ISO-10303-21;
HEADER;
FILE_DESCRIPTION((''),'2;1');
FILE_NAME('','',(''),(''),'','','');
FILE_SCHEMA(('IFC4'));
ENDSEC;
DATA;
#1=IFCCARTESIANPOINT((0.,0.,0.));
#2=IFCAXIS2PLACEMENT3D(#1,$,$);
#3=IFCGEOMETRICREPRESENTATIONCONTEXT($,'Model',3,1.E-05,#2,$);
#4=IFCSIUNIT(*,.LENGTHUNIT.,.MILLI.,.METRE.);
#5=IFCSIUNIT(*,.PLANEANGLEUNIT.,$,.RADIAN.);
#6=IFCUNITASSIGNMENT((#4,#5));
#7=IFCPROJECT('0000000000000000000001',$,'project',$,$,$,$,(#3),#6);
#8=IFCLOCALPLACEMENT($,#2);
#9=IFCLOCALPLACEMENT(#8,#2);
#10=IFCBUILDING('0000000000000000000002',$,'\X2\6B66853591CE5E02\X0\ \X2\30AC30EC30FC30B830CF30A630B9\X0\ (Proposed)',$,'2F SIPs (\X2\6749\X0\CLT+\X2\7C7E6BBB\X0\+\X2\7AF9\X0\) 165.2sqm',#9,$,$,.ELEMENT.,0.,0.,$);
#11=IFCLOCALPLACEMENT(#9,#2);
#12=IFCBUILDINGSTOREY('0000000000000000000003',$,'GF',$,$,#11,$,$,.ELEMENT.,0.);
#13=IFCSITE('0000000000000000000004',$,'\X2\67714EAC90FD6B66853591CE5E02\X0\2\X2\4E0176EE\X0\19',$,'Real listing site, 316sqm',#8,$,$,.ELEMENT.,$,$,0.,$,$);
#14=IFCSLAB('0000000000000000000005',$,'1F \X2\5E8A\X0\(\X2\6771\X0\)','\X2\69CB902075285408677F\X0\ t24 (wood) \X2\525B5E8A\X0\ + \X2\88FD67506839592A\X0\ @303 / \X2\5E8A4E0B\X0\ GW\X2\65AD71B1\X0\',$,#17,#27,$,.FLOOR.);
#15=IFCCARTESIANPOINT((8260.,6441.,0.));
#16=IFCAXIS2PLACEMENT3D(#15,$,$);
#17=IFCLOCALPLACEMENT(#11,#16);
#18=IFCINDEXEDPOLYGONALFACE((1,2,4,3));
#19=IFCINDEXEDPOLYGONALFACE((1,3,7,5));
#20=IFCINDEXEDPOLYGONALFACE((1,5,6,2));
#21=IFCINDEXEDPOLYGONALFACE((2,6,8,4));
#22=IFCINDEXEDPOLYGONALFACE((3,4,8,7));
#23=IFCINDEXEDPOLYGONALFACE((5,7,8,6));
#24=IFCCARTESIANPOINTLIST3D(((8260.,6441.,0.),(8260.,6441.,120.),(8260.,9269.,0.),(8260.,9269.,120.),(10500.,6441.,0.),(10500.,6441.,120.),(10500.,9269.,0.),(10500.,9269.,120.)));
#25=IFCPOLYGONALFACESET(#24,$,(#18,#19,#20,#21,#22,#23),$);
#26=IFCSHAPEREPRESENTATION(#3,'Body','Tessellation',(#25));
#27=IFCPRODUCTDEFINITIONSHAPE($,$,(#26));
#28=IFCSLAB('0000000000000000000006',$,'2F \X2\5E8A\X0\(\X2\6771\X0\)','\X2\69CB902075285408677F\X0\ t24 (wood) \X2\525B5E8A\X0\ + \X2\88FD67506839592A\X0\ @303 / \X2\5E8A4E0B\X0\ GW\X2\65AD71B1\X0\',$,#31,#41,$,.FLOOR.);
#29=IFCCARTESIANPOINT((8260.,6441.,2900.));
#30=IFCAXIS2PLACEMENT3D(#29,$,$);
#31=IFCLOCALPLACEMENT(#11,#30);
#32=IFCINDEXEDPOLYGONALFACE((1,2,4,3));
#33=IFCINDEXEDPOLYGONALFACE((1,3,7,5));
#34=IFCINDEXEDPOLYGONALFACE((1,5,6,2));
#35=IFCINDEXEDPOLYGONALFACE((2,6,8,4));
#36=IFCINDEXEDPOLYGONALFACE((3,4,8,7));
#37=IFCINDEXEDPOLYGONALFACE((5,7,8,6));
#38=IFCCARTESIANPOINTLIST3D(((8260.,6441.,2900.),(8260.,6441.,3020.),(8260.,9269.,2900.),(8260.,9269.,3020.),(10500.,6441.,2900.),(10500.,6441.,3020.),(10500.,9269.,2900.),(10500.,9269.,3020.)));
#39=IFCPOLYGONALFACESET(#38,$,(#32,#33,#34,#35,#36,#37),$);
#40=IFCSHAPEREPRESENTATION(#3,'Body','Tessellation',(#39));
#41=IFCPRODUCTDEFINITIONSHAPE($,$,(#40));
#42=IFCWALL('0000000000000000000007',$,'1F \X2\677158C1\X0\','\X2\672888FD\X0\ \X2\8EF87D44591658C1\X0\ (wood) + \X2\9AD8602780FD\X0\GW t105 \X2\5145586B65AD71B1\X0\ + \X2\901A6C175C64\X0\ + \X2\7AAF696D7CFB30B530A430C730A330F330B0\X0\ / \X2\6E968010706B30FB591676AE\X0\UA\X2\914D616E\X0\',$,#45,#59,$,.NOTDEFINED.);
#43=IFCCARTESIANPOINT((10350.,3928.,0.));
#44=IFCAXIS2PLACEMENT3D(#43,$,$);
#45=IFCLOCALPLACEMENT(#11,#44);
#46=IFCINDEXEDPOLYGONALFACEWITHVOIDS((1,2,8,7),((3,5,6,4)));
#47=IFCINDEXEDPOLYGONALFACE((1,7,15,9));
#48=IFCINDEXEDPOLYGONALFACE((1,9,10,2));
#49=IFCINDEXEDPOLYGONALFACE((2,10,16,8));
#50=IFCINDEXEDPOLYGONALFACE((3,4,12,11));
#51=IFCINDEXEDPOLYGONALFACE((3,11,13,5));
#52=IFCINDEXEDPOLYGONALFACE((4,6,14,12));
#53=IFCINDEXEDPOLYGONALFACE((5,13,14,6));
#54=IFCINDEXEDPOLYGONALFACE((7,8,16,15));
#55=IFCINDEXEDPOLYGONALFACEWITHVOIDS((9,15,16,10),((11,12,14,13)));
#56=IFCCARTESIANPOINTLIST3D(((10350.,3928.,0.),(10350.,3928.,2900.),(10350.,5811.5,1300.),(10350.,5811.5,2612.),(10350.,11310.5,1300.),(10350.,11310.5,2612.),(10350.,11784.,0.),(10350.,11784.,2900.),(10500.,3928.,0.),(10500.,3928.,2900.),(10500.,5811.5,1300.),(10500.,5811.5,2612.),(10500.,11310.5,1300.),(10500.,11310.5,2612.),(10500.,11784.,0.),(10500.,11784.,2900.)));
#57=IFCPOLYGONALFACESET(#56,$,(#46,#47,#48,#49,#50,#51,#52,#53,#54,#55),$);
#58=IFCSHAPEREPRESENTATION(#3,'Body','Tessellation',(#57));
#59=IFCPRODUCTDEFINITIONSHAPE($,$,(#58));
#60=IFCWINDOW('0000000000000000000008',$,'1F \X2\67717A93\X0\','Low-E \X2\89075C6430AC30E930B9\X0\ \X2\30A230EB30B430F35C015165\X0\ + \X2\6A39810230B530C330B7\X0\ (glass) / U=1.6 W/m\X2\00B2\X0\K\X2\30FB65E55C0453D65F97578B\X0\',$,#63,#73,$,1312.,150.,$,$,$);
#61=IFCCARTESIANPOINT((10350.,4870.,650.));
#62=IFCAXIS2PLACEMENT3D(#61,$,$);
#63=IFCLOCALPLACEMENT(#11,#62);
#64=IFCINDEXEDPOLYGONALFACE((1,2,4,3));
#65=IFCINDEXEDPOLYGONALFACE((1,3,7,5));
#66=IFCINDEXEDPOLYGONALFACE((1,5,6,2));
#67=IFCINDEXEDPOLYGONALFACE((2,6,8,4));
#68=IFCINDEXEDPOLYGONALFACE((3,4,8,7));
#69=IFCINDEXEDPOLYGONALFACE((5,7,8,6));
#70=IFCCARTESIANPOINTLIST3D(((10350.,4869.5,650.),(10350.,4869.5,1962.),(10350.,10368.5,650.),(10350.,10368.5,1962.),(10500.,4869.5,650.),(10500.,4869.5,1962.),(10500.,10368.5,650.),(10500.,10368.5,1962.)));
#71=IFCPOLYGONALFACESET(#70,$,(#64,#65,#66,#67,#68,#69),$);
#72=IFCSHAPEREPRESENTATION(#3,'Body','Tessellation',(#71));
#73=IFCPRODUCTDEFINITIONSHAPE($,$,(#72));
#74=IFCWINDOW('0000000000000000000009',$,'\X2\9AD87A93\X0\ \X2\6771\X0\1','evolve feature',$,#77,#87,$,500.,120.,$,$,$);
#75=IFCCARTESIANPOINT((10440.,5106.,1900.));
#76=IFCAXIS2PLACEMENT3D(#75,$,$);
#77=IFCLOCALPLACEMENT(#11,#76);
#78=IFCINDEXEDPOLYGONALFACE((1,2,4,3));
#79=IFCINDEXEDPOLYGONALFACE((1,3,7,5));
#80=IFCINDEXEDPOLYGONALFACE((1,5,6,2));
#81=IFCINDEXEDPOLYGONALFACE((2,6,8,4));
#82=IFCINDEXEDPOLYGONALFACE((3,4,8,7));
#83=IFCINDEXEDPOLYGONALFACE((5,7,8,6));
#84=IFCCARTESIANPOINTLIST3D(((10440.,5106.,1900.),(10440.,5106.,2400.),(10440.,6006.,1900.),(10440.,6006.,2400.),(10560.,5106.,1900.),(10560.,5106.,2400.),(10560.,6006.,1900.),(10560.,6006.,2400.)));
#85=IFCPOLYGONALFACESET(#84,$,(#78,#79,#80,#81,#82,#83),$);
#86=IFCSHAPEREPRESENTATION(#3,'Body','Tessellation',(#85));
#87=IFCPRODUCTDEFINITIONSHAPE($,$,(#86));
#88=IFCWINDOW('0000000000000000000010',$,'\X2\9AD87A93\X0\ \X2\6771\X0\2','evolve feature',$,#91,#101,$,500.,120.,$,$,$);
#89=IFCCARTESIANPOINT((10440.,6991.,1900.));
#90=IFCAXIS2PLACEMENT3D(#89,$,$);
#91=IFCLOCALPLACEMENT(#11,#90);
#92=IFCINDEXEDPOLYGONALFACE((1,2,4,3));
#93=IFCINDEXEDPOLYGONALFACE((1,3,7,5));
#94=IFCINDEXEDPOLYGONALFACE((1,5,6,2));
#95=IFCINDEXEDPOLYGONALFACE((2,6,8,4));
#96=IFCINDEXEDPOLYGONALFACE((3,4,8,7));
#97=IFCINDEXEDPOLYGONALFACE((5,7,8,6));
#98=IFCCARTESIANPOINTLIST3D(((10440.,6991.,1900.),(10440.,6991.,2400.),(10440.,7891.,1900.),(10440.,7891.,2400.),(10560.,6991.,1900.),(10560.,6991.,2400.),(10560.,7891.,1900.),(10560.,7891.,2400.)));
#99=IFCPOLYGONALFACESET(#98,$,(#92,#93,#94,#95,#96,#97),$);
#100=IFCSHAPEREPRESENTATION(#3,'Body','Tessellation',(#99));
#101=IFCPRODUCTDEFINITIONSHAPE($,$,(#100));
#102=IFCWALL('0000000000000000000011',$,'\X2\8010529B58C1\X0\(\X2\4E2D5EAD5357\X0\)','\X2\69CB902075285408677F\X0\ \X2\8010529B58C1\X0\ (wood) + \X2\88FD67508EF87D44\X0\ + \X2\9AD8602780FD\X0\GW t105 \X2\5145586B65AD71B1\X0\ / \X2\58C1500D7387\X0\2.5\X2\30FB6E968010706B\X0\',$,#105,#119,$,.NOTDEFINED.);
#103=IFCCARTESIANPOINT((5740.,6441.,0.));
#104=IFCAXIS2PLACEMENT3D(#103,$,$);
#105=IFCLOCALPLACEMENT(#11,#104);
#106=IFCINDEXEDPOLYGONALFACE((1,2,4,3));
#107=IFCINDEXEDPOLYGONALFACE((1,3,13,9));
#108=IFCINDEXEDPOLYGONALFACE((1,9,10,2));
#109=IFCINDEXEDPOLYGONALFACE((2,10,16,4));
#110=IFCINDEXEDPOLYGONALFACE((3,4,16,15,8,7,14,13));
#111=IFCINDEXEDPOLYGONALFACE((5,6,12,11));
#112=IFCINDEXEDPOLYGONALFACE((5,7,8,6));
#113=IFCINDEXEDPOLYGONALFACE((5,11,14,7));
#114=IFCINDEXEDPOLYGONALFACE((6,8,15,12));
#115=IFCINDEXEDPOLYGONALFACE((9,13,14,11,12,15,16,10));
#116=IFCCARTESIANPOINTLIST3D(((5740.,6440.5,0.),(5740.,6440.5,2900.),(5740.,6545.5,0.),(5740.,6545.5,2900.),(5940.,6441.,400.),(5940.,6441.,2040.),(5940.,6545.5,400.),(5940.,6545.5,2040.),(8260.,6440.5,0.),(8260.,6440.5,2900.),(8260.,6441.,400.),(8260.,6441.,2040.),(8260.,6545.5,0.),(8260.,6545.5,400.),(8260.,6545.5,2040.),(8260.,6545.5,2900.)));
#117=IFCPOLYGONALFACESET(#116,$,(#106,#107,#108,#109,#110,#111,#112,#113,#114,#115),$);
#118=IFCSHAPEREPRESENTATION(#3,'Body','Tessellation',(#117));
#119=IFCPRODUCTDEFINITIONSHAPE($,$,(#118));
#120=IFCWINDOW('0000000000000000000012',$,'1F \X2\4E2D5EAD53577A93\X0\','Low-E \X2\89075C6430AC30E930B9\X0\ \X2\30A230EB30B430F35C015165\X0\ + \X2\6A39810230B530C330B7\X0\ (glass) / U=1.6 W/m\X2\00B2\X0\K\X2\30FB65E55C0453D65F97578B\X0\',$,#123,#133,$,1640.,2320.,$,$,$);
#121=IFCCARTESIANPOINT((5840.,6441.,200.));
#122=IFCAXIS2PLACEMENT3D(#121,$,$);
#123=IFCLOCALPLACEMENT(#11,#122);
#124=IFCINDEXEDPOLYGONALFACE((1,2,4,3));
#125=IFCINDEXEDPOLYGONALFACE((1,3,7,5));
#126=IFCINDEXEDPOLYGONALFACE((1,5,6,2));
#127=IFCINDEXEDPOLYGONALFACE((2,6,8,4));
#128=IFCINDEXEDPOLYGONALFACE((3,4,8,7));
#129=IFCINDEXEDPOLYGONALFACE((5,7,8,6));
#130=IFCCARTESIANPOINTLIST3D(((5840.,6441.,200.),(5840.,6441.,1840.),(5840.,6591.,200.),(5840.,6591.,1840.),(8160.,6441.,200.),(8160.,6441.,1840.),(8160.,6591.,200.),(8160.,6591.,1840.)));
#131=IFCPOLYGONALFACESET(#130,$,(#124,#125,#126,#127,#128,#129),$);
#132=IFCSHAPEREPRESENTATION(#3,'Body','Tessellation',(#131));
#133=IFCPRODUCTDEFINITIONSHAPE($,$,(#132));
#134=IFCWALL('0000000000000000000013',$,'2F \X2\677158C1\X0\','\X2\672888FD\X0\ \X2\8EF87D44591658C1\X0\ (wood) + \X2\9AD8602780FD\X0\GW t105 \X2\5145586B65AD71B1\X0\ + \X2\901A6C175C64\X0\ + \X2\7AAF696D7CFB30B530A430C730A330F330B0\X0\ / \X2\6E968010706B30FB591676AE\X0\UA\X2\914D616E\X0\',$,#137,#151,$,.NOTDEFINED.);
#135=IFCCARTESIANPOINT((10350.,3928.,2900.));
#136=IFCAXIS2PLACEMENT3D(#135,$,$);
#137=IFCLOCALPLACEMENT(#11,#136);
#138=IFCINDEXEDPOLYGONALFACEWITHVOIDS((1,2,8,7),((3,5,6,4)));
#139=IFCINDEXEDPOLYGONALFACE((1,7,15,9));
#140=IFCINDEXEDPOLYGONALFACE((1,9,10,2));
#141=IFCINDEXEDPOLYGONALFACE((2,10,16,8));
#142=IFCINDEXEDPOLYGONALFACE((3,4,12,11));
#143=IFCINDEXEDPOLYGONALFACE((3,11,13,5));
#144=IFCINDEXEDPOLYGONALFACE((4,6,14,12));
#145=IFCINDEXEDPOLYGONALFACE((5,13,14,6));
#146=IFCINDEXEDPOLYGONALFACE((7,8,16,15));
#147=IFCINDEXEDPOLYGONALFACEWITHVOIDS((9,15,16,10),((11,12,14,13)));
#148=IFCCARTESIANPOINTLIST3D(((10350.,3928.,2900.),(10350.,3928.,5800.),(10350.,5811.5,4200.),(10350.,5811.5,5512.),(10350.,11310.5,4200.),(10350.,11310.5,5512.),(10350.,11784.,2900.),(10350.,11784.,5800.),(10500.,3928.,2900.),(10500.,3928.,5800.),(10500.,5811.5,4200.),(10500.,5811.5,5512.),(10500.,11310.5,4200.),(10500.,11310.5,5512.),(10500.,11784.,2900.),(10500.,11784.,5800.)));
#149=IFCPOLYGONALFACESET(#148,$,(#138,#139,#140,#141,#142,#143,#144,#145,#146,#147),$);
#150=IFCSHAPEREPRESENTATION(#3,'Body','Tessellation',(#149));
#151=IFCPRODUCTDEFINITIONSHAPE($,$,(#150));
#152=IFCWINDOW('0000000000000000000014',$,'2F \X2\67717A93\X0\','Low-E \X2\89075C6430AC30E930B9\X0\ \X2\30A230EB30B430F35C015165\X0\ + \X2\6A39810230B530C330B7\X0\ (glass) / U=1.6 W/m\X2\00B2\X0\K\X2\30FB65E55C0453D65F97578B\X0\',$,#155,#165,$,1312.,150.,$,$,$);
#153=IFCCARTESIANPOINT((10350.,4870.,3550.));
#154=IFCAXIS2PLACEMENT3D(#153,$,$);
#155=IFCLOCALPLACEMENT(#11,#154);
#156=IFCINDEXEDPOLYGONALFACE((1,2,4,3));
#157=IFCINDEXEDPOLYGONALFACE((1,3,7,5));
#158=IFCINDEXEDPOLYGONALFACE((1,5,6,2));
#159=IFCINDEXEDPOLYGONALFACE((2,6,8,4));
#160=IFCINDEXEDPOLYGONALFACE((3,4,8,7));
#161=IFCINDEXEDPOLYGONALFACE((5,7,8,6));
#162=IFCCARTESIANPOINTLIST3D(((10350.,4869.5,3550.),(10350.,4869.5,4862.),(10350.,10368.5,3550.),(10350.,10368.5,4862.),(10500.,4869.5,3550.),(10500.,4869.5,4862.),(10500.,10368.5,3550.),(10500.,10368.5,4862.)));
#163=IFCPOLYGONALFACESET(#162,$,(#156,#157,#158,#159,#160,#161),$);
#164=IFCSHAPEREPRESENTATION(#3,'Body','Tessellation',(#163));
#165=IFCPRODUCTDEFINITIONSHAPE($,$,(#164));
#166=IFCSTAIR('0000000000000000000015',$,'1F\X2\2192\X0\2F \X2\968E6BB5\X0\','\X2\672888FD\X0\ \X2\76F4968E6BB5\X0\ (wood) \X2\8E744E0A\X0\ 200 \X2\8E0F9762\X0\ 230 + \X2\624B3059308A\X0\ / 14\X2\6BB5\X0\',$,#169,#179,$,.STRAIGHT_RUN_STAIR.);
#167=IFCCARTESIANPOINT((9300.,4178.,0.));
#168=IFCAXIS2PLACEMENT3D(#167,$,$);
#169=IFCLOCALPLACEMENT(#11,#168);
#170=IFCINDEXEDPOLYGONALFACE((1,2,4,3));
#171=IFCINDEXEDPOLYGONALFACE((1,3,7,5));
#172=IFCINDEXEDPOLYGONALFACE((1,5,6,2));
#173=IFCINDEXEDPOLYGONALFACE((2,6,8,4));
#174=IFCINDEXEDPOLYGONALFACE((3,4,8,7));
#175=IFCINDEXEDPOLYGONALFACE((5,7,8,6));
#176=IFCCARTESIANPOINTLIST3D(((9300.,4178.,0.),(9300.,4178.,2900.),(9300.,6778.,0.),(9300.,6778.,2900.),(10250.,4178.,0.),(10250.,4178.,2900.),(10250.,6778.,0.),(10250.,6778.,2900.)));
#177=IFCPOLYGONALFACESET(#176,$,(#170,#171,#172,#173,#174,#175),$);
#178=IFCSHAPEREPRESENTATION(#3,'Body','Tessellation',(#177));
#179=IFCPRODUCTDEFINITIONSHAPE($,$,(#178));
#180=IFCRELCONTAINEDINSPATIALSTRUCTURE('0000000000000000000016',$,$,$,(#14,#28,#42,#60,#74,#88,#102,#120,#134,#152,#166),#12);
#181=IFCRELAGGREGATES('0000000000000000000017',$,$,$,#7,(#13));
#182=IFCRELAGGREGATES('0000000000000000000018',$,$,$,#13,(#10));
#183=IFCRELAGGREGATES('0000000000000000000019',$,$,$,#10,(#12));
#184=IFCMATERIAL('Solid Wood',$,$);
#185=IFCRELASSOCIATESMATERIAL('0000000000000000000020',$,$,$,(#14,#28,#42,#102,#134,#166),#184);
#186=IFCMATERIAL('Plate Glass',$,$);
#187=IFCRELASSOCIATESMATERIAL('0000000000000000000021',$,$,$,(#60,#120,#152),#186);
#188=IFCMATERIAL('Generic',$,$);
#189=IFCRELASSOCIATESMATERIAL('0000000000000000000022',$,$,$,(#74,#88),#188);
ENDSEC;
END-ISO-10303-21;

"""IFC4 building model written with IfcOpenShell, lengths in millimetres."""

from ifc_helpers import new_model, si_unit, frame, frame_2d, origin, place, context, project, spatial, rectangle, extrude, material, element, fill, save


model = new_model("IFC4")

# Units and contexts
model_context = context("Model", 3, precision=1e-05, world=origin())
ifc_project = project(units=[si_unit("LENGTHUNIT", "METRE", prefix="MILLI"), si_unit("PLANEANGLEUNIT", "RADIAN")], contexts=[model_context])

# Site, building, storey
site_placement = place(None, origin())
site = spatial("IfcSite", under=ifc_project, at=site_placement, Name="東京都武蔵野市2丁目19", ObjectType="Real listing site, 316sqm", CompositionType="ELEMENT", RefElevation=0.0)
building_placement = place(site_placement, origin())
building = spatial("IfcBuilding", under=site, at=building_placement, Name="武蔵野市 ガレージハウス (Proposed)", ObjectType="2F SIPs (杉CLT+籾殻+竹) 165.2sqm", CompositionType="ELEMENT", ElevationOfRefHeight=0.0, ElevationOfTerrain=0.0)
storey_placement = place(building_placement, origin())
storey = spatial("IfcBuildingStorey", under=building, at=storey_placement, Name="GF", CompositionType="ELEMENT", Elevation=0.0)

# Slabs
ifc_material_1 = material(Name="Solid Wood")
slab_1_placement = place(storey_placement, frame((8260.0, 6441.0, 0.0)))
element("IfcSlab", 1, at=slab_1_placement, inside=storey, material=ifc_material_1, Name="1F 床(東)", Description="構造用合板 t24 (wood) 剛床 + 製材根太 @303 / 床下 GW断熱", PredefinedType="FLOOR", context=model_context, shape_type="SweptSolid", body=[
    extrude(rectangle(XDim=2240.0, YDim=2828.0, at=frame_2d((1120.0, 1414.0))), frame((8260.0, 6441.0, 0.0)), (0.0, 0.0, 1.0), 120.0),
])
slab_2_placement = place(storey_placement, frame((8260.0, 6441.0, 2900.0)))
element("IfcSlab", 2, at=slab_2_placement, inside=storey, material=ifc_material_1, Name="2F 床(東)", Description="構造用合板 t24 (wood) 剛床 + 製材根太 @303 / 床下 GW断熱", PredefinedType="FLOOR", context=model_context, shape_type="SweptSolid", body=[
    extrude(rectangle(XDim=2240.0, YDim=2828.0, at=frame_2d((1120.0, 1414.0))), frame((8260.0, 6441.0, 2900.0)), (0.0, 0.0, 1.0), 120.0),
])

# Wall, openings, windows
wall_1_placement = place(storey_placement, frame((10350.0, 3928.0, 0.0)))
wall_1 = element("IfcWall", 3, at=wall_1_placement, inside=storey, material=ifc_material_1, Name="1F 東壁", Description="木製 軸組外壁 (wood) + 高性能GW t105 充填断熱 + 通気層 + 窯業系サイディング / 準耐火・外皮UA配慮", PredefinedType="NOTDEFINED", context=model_context, shape_type="SweptSolid", body=[
    extrude(rectangle(XDim=150.0, YDim=7856.0, at=frame_2d((75.0, 3928.0))), frame((10350.0, 3928.0, 0.0)), (0.0, 0.0, 1.0), 2900.0),
])
opening_1_placement = place(storey_placement, frame((10350.0, 4870.0, 650.0)))
opening_1 = element("IfcOpeningElement", 4, at=opening_1_placement, cuts=wall_1, PredefinedType="NOTDEFINED", context=model_context, shape_type="SweptSolid", body=[
    extrude(rectangle(XDim=150.0, YDim=5499.0, at=frame_2d((75.0, 2749.0))), frame((10350.0, 4870.0, 650.0)), (0.0, 0.0, 1.0), 1312.0),
])
opening_2_placement = place(storey_placement, frame((10440.0, 5106.0, 1900.0)))
opening_2 = element("IfcOpeningElement", 5, at=opening_2_placement, cuts=wall_1, PredefinedType="NOTDEFINED", context=model_context, shape_type="SweptSolid", body=[
    extrude(rectangle(XDim=120.0, YDim=900.0, at=frame_2d((60.0, 450.0))), frame((10440.0, 5106.0, 1900.0)), (0.0, 0.0, 1.0), 500.0),
])
opening_3_placement = place(storey_placement, frame((10440.0, 6991.0, 1900.0)))
opening_3 = element("IfcOpeningElement", 6, at=opening_3_placement, cuts=wall_1, PredefinedType="NOTDEFINED", context=model_context, shape_type="SweptSolid", body=[
    extrude(rectangle(XDim=120.0, YDim=900.0, at=frame_2d((60.0, 450.0))), frame((10440.0, 6991.0, 1900.0)), (0.0, 0.0, 1.0), 500.0),
])
ifc_material_2 = material(Name="Plate Glass")
window_1_placement = place(storey_placement, frame((10350.0, 4870.0, 650.0)))
window_1 = element("IfcWindow", 7, at=window_1_placement, inside=storey, material=ifc_material_2, Name="1F 東窓", Description="Low-E 複層ガラス アルゴン封入 + 樹脂サッシ (glass) / U=1.6 W/m²K・日射取得型", OverallHeight=1312.0, OverallWidth=150.0, context=model_context, shape_type="SweptSolid", body=[
    extrude(rectangle(XDim=150.0, YDim=5499.0, at=frame_2d((75.0, 2749.0))), frame((10350.0, 4870.0, 650.0)), (0.0, 0.0, 1.0), 1312.0),
])
fill(opening_1, window_1)
ifc_material_3 = material(Name="Generic")
window_2_placement = place(storey_placement, frame((10440.0, 5106.0, 1900.0)))
window_2 = element("IfcWindow", 8, at=window_2_placement, inside=storey, material=ifc_material_3, Name="高窓 東1", Description="evolve feature", OverallHeight=500.0, OverallWidth=120.0, context=model_context, shape_type="SweptSolid", body=[
    extrude(rectangle(XDim=120.0, YDim=900.0, at=frame_2d((60.0, 450.0))), frame((10440.0, 5106.0, 1900.0)), (0.0, 0.0, 1.0), 500.0),
])
fill(opening_2, window_2)
window_3_placement = place(storey_placement, frame((10440.0, 6991.0, 1900.0)))
window_3 = element("IfcWindow", 9, at=window_3_placement, inside=storey, material=ifc_material_3, Name="高窓 東2", Description="evolve feature", OverallHeight=500.0, OverallWidth=120.0, context=model_context, shape_type="SweptSolid", body=[
    extrude(rectangle(XDim=120.0, YDim=900.0, at=frame_2d((60.0, 450.0))), frame((10440.0, 6991.0, 1900.0)), (0.0, 0.0, 1.0), 500.0),
])
fill(opening_3, window_3)

# Wall, opening, window
wall_2_placement = place(storey_placement, frame((5740.0, 6441.0, 0.0)))
wall_2 = element("IfcWall", 10, at=wall_2_placement, inside=storey, material=ifc_material_1, Name="耐力壁(中庭南)", Description="構造用合板 耐力壁 (wood) + 製材軸組 + 高性能GW t105 充填断熱 / 壁倍率2.5・準耐火", PredefinedType="NOTDEFINED", context=model_context, shape_type="SweptSolid", body=[
    extrude(rectangle(XDim=2520.0, YDim=105.0, at=frame_2d((1260.0, 52.0))), frame((5740.0, 6441.0, 0.0)), (0.0, 0.0, 1.0), 2900.0),
])
opening_4_placement = place(storey_placement, frame((5840.0, 6441.0, 200.0)))
opening_4 = element("IfcOpeningElement", 11, at=opening_4_placement, cuts=wall_2, PredefinedType="NOTDEFINED", context=model_context, shape_type="SweptSolid", body=[
    extrude(rectangle(XDim=2320.0, YDim=150.0, at=frame_2d((1160.0, 75.0))), frame((5840.0, 6441.0, 200.0)), (0.0, 0.0, 1.0), 1640.0),
])
window_4_placement = place(storey_placement, frame((5840.0, 6441.0, 200.0)))
window_4 = element("IfcWindow", 12, at=window_4_placement, inside=storey, material=ifc_material_2, Name="1F 中庭南窓", Description="Low-E 複層ガラス アルゴン封入 + 樹脂サッシ (glass) / U=1.6 W/m²K・日射取得型", OverallHeight=1640.0, OverallWidth=2320.0, context=model_context, shape_type="SweptSolid", body=[
    extrude(rectangle(XDim=2320.0, YDim=150.0, at=frame_2d((1160.0, 75.0))), frame((5840.0, 6441.0, 200.0)), (0.0, 0.0, 1.0), 1640.0),
])
fill(opening_4, window_4)

# Wall, opening, window
wall_3_placement = place(storey_placement, frame((10350.0, 3928.0, 2900.0)))
wall_3 = element("IfcWall", 13, at=wall_3_placement, inside=storey, material=ifc_material_1, Name="2F 東壁", Description="木製 軸組外壁 (wood) + 高性能GW t105 充填断熱 + 通気層 + 窯業系サイディング / 準耐火・外皮UA配慮", PredefinedType="NOTDEFINED", context=model_context, shape_type="SweptSolid", body=[
    extrude(rectangle(XDim=150.0, YDim=7856.0, at=frame_2d((75.0, 3928.0))), frame((10350.0, 3928.0, 2900.0)), (0.0, 0.0, 1.0), 2900.0),
])
opening_5_placement = place(storey_placement, frame((10350.0, 4870.0, 3550.0)))
opening_5 = element("IfcOpeningElement", 14, at=opening_5_placement, cuts=wall_3, PredefinedType="NOTDEFINED", context=model_context, shape_type="SweptSolid", body=[
    extrude(rectangle(XDim=150.0, YDim=5499.0, at=frame_2d((75.0, 2749.0))), frame((10350.0, 4870.0, 3550.0)), (0.0, 0.0, 1.0), 1312.0),
])
window_5_placement = place(storey_placement, frame((10350.0, 4870.0, 3550.0)))
window_5 = element("IfcWindow", 15, at=window_5_placement, inside=storey, material=ifc_material_2, Name="2F 東窓", Description="Low-E 複層ガラス アルゴン封入 + 樹脂サッシ (glass) / U=1.6 W/m²K・日射取得型", OverallHeight=1312.0, OverallWidth=150.0, context=model_context, shape_type="SweptSolid", body=[
    extrude(rectangle(XDim=150.0, YDim=5499.0, at=frame_2d((75.0, 2749.0))), frame((10350.0, 4870.0, 3550.0)), (0.0, 0.0, 1.0), 1312.0),
])
fill(opening_5, window_5)

# Stair
stair_placement = place(storey_placement, frame((9300.0, 4178.0, 0.0)))
element("IfcStair", 16, at=stair_placement, inside=storey, material=ifc_material_1, Name="1F→2F 階段", Description="木製 直階段 (wood) 蹴上 200 踏面 230 + 手すり / 14段", PredefinedType="STRAIGHT_RUN_STAIR", context=model_context, shape_type="SweptSolid", body=[
    extrude(rectangle(XDim=950.0, YDim=2600.0, at=frame_2d((475.0, 1300.0))), frame((9300.0, 4178.0, 0.0)), (0.0, 0.0, 1.0), 2900.0),
])

save(model, "model.ifc")
